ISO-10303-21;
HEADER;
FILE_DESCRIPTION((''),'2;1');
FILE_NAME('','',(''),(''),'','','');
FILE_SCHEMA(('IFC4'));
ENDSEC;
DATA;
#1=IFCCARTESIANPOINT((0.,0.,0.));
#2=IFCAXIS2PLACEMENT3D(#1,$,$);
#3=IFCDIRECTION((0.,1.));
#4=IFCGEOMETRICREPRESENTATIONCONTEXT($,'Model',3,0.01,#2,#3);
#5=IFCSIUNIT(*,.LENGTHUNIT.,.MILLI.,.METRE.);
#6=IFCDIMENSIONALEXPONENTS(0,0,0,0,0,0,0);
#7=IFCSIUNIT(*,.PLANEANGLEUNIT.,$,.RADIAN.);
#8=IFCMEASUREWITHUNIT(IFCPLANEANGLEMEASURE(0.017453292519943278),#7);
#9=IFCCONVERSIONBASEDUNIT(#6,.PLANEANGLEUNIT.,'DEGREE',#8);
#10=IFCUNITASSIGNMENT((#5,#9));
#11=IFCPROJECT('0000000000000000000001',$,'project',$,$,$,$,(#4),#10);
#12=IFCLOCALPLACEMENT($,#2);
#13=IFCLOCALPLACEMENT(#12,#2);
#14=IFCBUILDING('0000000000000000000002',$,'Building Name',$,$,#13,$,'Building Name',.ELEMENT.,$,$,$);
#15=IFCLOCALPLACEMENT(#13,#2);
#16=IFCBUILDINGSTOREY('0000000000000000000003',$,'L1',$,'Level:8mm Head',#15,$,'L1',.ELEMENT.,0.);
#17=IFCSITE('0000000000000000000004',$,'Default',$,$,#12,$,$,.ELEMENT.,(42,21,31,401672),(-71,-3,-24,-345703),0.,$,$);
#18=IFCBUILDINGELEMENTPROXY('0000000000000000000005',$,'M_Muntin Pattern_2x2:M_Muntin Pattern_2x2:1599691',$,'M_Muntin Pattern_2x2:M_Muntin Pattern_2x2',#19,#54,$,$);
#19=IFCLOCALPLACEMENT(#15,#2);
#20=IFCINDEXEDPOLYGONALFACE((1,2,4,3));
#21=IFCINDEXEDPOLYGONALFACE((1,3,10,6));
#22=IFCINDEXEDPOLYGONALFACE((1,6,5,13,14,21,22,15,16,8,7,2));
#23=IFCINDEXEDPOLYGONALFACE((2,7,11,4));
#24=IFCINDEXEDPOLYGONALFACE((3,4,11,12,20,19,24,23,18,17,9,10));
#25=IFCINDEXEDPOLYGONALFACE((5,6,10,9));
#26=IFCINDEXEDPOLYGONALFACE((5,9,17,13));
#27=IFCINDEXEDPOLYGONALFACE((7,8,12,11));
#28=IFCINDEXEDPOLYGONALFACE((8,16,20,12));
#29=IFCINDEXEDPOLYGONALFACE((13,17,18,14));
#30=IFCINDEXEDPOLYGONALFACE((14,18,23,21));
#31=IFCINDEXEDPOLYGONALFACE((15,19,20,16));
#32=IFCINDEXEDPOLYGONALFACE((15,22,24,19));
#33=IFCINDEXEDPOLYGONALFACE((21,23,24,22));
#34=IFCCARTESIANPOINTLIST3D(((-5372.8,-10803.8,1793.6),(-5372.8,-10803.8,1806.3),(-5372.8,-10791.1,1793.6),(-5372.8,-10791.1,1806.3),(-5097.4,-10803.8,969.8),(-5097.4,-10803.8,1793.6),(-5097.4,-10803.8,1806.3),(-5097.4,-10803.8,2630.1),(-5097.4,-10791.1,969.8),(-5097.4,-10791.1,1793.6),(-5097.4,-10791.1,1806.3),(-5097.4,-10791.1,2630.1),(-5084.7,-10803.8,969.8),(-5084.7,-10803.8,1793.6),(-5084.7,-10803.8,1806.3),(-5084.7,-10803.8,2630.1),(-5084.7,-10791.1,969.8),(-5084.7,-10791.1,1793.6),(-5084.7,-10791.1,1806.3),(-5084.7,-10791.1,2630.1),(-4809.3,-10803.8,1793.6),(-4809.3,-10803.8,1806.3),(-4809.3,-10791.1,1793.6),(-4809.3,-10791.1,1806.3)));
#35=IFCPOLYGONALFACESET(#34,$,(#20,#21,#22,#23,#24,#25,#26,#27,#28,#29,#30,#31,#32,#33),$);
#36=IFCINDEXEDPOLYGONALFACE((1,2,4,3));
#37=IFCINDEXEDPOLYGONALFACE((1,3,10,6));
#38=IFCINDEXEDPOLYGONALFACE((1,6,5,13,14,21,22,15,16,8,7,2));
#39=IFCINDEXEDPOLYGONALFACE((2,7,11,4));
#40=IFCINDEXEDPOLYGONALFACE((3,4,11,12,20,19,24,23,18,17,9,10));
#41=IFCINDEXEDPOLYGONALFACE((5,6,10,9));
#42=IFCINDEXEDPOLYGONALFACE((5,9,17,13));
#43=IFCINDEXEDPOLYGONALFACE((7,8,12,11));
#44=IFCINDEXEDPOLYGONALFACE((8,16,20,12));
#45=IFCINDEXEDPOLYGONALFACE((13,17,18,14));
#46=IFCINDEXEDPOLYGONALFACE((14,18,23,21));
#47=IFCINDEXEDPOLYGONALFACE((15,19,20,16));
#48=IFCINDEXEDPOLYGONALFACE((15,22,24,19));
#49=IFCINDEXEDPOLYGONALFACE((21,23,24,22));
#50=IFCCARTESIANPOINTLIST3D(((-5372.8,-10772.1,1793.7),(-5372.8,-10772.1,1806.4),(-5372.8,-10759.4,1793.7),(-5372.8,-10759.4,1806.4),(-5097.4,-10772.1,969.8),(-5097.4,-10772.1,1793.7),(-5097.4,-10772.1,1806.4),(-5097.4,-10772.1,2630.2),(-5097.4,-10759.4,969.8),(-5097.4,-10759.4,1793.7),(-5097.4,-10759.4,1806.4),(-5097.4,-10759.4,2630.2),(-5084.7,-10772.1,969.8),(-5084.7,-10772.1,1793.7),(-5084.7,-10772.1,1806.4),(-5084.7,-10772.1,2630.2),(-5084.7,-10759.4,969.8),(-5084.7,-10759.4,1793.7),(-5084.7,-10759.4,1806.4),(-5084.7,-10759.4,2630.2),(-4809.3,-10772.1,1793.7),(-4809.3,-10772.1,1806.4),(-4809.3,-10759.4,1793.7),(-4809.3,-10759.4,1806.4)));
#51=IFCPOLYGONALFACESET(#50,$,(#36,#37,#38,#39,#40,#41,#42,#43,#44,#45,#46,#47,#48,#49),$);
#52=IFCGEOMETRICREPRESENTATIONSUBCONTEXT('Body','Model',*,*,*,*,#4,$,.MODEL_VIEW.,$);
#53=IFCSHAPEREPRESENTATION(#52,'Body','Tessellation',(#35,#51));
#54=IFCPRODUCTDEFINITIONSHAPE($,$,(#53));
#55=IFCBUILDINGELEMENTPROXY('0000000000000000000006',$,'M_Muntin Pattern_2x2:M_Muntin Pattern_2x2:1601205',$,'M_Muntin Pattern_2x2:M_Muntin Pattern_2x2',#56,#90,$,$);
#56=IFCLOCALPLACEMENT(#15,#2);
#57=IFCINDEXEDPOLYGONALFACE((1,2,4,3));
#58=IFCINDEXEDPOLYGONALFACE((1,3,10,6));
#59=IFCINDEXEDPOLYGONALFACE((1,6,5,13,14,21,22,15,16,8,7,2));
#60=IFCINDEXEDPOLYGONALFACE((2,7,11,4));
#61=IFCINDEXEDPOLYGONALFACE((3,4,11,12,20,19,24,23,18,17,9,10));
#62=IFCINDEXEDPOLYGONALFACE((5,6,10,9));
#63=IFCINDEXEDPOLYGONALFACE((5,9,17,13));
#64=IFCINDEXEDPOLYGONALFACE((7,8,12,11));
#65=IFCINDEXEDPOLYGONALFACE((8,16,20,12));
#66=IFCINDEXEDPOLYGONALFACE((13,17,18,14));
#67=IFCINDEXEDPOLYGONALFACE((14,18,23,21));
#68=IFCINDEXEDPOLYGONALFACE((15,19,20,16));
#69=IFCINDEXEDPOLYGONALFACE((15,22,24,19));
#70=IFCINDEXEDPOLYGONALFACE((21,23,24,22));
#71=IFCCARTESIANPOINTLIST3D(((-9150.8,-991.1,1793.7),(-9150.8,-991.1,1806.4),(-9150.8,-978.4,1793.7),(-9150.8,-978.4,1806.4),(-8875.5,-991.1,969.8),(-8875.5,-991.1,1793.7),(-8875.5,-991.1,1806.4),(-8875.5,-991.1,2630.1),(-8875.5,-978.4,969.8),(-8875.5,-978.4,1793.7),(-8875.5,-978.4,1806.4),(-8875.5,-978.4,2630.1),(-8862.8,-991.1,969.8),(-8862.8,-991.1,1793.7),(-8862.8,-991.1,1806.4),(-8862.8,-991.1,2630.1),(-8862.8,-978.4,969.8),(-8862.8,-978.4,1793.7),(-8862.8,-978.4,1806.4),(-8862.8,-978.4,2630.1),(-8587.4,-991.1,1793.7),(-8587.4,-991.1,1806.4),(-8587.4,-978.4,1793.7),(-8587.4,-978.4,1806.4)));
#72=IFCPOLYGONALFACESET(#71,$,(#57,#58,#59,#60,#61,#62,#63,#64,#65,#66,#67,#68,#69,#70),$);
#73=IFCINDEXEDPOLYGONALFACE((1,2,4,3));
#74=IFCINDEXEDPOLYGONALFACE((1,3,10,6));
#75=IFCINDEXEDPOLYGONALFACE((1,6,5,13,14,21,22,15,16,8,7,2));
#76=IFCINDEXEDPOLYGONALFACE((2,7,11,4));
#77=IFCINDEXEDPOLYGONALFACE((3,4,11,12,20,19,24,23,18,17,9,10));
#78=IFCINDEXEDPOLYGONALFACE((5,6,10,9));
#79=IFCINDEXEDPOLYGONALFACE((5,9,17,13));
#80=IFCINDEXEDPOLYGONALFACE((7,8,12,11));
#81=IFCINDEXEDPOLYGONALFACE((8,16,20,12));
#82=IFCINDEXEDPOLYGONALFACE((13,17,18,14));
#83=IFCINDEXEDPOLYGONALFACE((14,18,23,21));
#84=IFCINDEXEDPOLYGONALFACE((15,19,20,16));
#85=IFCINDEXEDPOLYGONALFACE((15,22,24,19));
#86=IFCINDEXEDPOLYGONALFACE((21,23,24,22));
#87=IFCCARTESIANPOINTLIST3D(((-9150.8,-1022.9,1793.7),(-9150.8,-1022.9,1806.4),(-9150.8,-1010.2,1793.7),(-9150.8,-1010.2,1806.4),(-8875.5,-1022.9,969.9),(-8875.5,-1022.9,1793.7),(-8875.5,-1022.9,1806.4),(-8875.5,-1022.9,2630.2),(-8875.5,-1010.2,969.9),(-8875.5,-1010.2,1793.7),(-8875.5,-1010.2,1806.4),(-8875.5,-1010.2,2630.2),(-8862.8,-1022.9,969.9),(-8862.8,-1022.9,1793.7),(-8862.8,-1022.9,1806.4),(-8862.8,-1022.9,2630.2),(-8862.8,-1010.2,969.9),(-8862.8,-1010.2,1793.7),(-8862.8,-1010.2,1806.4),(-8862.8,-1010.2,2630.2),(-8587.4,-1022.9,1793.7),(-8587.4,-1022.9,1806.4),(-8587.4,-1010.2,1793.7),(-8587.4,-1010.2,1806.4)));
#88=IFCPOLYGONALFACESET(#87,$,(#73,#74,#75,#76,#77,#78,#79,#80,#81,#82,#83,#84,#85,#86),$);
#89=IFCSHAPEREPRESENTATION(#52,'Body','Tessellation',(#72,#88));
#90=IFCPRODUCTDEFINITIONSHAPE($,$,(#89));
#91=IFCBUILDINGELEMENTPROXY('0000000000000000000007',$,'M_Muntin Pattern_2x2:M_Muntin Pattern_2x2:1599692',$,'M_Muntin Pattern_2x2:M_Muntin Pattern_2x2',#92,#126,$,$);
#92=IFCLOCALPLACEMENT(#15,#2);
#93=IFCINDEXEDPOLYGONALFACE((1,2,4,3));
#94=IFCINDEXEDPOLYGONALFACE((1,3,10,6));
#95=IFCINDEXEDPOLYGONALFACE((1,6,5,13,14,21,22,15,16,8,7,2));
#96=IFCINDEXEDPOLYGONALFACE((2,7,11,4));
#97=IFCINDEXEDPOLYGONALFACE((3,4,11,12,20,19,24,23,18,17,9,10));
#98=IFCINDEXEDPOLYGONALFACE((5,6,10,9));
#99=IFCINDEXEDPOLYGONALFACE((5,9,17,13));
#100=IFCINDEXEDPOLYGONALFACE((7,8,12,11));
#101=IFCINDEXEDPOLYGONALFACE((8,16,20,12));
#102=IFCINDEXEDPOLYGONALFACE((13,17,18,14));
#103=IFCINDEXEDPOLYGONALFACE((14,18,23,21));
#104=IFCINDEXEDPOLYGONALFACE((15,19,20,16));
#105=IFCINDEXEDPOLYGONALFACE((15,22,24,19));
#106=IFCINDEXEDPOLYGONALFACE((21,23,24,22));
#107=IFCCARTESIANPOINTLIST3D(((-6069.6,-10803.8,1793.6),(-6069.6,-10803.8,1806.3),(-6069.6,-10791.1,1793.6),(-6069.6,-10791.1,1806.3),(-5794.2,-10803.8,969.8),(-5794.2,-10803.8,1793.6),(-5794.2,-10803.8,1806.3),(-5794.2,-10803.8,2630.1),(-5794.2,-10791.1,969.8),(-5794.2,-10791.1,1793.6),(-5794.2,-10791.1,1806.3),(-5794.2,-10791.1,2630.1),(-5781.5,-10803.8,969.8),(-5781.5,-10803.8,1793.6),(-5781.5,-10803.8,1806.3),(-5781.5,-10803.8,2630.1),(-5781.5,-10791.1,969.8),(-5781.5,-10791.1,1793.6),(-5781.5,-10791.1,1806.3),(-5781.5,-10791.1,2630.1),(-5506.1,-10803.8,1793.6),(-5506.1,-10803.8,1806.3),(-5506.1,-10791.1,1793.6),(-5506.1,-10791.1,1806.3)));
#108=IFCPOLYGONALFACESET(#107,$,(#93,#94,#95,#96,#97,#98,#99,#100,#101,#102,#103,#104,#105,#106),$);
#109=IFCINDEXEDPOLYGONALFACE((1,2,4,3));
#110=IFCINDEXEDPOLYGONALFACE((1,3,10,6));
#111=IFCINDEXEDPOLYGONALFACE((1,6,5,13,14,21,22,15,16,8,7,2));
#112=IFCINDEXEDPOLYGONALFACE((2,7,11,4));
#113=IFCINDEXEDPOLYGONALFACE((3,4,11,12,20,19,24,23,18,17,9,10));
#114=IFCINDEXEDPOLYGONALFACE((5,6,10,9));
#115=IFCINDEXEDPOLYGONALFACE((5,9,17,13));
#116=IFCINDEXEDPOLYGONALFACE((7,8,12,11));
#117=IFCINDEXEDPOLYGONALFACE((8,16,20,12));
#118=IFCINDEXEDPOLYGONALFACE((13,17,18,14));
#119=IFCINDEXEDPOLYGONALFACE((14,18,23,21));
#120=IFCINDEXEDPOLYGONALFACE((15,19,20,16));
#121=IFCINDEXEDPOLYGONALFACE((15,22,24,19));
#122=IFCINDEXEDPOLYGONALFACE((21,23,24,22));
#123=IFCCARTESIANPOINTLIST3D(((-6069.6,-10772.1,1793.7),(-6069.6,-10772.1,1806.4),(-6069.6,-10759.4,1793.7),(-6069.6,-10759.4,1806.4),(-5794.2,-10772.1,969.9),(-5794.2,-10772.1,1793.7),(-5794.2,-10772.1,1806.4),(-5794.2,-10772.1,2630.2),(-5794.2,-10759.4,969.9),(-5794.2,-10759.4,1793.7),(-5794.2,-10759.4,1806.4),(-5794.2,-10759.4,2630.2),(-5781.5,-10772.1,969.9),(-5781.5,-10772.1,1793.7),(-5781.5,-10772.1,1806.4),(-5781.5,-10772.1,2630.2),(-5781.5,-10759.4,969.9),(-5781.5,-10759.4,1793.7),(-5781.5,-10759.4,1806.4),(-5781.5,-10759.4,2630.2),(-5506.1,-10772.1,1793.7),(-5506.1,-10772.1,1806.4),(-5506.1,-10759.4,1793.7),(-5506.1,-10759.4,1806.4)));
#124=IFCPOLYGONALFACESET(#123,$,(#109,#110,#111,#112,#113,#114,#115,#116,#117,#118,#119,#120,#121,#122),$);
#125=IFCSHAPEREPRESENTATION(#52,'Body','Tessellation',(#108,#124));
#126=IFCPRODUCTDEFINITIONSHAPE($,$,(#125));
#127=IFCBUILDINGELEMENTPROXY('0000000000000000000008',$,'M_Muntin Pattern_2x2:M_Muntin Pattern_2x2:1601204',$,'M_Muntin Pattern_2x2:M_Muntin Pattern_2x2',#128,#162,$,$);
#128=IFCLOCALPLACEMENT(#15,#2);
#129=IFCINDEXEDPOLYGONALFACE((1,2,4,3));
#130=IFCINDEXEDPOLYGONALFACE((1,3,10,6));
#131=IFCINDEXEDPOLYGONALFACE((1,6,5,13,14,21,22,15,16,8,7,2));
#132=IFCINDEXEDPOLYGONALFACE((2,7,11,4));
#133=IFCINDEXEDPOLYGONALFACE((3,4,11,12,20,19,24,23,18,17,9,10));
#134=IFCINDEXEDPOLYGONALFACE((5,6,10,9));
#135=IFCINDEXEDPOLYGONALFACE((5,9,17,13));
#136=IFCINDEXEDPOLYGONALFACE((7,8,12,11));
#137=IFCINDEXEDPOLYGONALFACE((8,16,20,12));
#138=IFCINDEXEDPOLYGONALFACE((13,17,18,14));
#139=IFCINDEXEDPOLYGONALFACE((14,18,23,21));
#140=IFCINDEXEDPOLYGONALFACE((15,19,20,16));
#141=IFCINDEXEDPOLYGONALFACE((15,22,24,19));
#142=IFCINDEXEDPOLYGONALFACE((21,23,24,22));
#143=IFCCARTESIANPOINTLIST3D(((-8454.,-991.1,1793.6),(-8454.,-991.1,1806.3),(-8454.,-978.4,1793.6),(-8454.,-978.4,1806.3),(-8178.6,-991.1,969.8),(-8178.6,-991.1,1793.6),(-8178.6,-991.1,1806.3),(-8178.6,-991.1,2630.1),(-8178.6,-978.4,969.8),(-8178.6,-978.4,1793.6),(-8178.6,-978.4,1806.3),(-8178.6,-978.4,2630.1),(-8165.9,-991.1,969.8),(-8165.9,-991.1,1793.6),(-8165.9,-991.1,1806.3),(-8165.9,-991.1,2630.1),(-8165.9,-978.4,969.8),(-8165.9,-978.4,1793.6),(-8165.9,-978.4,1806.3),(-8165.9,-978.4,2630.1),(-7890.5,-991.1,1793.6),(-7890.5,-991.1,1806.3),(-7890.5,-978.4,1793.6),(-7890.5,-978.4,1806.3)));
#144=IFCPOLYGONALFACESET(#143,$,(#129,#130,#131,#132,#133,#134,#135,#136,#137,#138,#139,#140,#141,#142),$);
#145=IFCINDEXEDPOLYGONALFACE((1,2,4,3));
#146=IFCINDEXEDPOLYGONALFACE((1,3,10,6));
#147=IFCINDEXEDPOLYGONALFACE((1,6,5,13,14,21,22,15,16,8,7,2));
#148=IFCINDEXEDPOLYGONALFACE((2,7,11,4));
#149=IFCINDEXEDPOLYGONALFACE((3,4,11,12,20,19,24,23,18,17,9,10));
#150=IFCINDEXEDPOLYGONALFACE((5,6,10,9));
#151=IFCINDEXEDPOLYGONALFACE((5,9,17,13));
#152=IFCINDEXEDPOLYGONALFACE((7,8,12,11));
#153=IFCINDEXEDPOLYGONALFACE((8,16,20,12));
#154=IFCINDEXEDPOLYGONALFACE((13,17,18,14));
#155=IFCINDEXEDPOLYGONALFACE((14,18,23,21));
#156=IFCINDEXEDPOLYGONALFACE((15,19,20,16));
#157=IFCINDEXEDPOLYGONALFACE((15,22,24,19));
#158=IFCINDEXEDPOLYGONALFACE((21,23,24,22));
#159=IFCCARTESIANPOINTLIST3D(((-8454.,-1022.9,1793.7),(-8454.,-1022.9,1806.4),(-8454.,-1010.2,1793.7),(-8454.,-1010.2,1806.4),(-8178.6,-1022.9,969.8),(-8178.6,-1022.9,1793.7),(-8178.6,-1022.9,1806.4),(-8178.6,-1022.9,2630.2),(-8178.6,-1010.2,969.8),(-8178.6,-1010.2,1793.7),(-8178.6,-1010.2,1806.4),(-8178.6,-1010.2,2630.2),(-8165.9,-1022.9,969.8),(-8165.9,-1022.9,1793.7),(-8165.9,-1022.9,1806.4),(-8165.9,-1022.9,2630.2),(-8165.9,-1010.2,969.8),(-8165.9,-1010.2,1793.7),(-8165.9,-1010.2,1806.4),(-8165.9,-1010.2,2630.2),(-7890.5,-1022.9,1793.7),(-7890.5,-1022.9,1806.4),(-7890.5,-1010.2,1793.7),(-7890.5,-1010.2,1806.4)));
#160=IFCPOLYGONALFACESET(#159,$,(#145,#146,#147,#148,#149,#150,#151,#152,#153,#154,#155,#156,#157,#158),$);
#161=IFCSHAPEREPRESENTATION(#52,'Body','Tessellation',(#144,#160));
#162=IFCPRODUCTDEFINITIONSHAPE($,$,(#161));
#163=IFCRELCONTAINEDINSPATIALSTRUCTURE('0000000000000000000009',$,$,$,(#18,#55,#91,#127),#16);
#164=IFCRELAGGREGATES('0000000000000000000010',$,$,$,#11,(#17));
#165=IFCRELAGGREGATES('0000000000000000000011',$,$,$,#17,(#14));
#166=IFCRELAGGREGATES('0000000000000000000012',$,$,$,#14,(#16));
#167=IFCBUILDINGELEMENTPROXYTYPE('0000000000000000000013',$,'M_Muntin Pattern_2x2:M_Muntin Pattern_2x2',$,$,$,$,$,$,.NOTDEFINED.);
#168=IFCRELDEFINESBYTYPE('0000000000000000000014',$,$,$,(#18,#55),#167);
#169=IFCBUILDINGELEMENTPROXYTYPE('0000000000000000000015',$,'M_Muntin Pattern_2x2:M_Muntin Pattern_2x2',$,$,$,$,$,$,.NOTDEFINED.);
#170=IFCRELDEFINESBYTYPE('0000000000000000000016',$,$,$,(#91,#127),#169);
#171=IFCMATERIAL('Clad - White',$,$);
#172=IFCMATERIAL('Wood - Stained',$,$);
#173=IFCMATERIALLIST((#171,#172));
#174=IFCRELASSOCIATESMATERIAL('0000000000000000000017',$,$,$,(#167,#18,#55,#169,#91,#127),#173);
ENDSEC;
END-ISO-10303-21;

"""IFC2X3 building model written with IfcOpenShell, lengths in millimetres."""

from ifc_helpers import new_model, entity, si_unit, converted_unit, direction, frame, origin, place, context, subcontext, project, spatial, polyline, outline, extrude, source, transform, mapped, material, material_list, type_object, type_shapes, element, save


model = new_model("IFC2X3")

# Units and contexts
model_context = context("Model", 3, precision=0.01, world=origin(), true_north=direction((0.0, 1.0)))
body_context = subcontext(model_context, "Body", "Model", "MODEL_VIEW")
ifc_project = project(units=[si_unit("LENGTHUNIT", "METRE", prefix="MILLI"), converted_unit("PLANEANGLEUNIT", "DEGREE", entity("IfcPlaneAngleMeasure", 0.017453292519943278), si_unit("PLANEANGLEUNIT", "RADIAN"), dimensions=[0, 0, 0, 0, 0, 0, 0])], contexts=[model_context])

# Site, building, storey
site_placement = place(None, origin())
site = spatial("IfcSite", under=ifc_project, at=site_placement, Name="Default", CompositionType="ELEMENT", RefLatitude=(42, 21, 31, 401672), RefLongitude=(-71, -3, -24, -345703), RefElevation=0.0)
building_placement = place(site_placement, origin())
building = spatial("IfcBuilding", under=site, at=building_placement, Name="Building Name", LongName="Building Name", CompositionType="ELEMENT")
storey_placement = place(building_placement, origin())
storey = spatial("IfcBuildingStorey", under=building, at=storey_placement, Name="L1", ObjectType="Level:8mm Head", LongName="L1", CompositionType="ELEMENT", Elevation=0.0)

# Building element proxies
ifc_material_1 = material(Name="Clad - White")
ifc_material_2 = material(Name="Wood - Stained")
ifc_material_list = material_list([ifc_material_1, ifc_material_2])
building_element_proxy_type_1 = type_object("IfcBuildingElementProxyType", Name="M_Muntin Pattern_2x2:M_Muntin Pattern_2x2", PredefinedType="NOTDEFINED", material=ifc_material_list)
shared_shape_1 = source(origin(), body_context, "Body", "SweptSolid", [
    extrude(outline(polyline([(6.4, -6.4), (830.1, -6.4), (830.1, 6.3), (6.4, 6.3), (6.4, 281.7), (-6.3, 281.7), (-6.3, 6.3), (-830.2, 6.3), (-830.2, -6.4), (-6.3, -6.4), (-6.3, -281.7), (6.4, -281.7), (6.4, -6.4)])), frame((0.0, 9.5, 830.1), z_axis=(0.0, 1.0, 0.0), x_axis=(0.0, 0.0, 1.0)), (0.0, 0.0, 1.0), 12.7),
    extrude(outline(polyline([(6.4, -6.4), (830.2, -6.4), (830.2, 6.3), (6.4, 6.3), (6.4, 281.7), (-6.3, 281.7), (-6.3, 6.3), (-830.2, 6.3), (-830.2, -6.4), (-6.3, -6.4), (-6.3, -281.7), (6.4, -281.7), (6.4, -6.4)])), frame((0.0, -22.2, 830.2), z_axis=(0.0, 1.0, 0.0), x_axis=(0.0, 0.0, 1.0)), (0.0, 0.0, 1.0), 12.7),
])
type_shapes(building_element_proxy_type_1, [shared_shape_1])
proxy_1_placement = place(storey_placement, frame((-5091.0, -10781.6, 969.8), z_axis=(0.0, 0.0, 1.0), x_axis=(-1.0, 0.0, 0.0)))
element("IfcBuildingElementProxy", 1, at=proxy_1_placement, inside=storey, type_object=building_element_proxy_type_1, material=ifc_material_list, Name="M_Muntin Pattern_2x2:M_Muntin Pattern_2x2:1599691", ObjectType="M_Muntin Pattern_2x2:M_Muntin Pattern_2x2", context=body_context, shape_type="MappedRepresentation", body=[
    mapped(shared_shape_1, transform((0.0, 0.0, 0.0), scale=1.0)),
])
proxy_2_placement = place(storey_placement, frame((-8869.1, -1000.6, 969.9)))
element("IfcBuildingElementProxy", 2, at=proxy_2_placement, inside=storey, type_object=building_element_proxy_type_1, material=ifc_material_list, Name="M_Muntin Pattern_2x2:M_Muntin Pattern_2x2:1601205", ObjectType="M_Muntin Pattern_2x2:M_Muntin Pattern_2x2", context=body_context, shape_type="MappedRepresentation", body=[
    mapped(shared_shape_1, transform((0.0, 0.0, 0.0), scale=1.0)),
])
building_element_proxy_type_2 = type_object("IfcBuildingElementProxyType", Name="M_Muntin Pattern_2x2:M_Muntin Pattern_2x2", PredefinedType="NOTDEFINED", material=ifc_material_list)
shared_shape_2 = source(origin(), body_context, "Body", "SweptSolid", [
    extrude(outline(polyline([(6.4, -6.4), (830.1, -6.4), (830.1, 6.3), (6.4, 6.3), (6.4, 281.7), (-6.3, 281.7), (-6.3, 6.3), (-830.2, 6.3), (-830.2, -6.4), (-6.3, -6.4), (-6.3, -281.7), (6.4, -281.7), (6.4, -6.4)])), frame((0.0, -22.2, 830.1), z_axis=(0.0, 1.0, 0.0), x_axis=(0.0, 0.0, 1.0)), (0.0, 0.0, 1.0), 12.7),
    extrude(outline(polyline([(6.4, -6.4), (830.2, -6.4), (830.2, 6.3), (6.4, 6.3), (6.4, 281.7), (-6.3, 281.7), (-6.3, 6.3), (-830.2, 6.3), (-830.2, -6.4), (-6.3, -6.4), (-6.3, -281.7), (6.4, -281.7), (6.4, -6.4)])), frame((0.0, 9.5, 830.2), z_axis=(0.0, 1.0, 0.0), x_axis=(0.0, 0.0, 1.0)), (0.0, 0.0, 1.0), 12.7),
])
type_shapes(building_element_proxy_type_2, [shared_shape_2])
proxy_3_placement = place(storey_placement, frame((-5787.9, -10781.6, 969.9)))
element("IfcBuildingElementProxy", 3, at=proxy_3_placement, inside=storey, type_object=building_element_proxy_type_2, material=ifc_material_list, Name="M_Muntin Pattern_2x2:M_Muntin Pattern_2x2:1599692", ObjectType="M_Muntin Pattern_2x2:M_Muntin Pattern_2x2", context=body_context, shape_type="MappedRepresentation", body=[
    mapped(shared_shape_2, transform((0.0, 0.0, 0.0), scale=1.0)),
])
proxy_4_placement = place(storey_placement, frame((-8172.3, -1000.6, 969.8), z_axis=(0.0, 0.0, 1.0), x_axis=(-1.0, 0.0, 0.0)))
element("IfcBuildingElementProxy", 4, at=proxy_4_placement, inside=storey, type_object=building_element_proxy_type_2, material=ifc_material_list, Name="M_Muntin Pattern_2x2:M_Muntin Pattern_2x2:1601204", ObjectType="M_Muntin Pattern_2x2:M_Muntin Pattern_2x2", context=body_context, shape_type="MappedRepresentation", body=[
    mapped(shared_shape_2, transform((0.0, 0.0, 0.0), scale=1.0)),
])

save(model, "model.ifc")
